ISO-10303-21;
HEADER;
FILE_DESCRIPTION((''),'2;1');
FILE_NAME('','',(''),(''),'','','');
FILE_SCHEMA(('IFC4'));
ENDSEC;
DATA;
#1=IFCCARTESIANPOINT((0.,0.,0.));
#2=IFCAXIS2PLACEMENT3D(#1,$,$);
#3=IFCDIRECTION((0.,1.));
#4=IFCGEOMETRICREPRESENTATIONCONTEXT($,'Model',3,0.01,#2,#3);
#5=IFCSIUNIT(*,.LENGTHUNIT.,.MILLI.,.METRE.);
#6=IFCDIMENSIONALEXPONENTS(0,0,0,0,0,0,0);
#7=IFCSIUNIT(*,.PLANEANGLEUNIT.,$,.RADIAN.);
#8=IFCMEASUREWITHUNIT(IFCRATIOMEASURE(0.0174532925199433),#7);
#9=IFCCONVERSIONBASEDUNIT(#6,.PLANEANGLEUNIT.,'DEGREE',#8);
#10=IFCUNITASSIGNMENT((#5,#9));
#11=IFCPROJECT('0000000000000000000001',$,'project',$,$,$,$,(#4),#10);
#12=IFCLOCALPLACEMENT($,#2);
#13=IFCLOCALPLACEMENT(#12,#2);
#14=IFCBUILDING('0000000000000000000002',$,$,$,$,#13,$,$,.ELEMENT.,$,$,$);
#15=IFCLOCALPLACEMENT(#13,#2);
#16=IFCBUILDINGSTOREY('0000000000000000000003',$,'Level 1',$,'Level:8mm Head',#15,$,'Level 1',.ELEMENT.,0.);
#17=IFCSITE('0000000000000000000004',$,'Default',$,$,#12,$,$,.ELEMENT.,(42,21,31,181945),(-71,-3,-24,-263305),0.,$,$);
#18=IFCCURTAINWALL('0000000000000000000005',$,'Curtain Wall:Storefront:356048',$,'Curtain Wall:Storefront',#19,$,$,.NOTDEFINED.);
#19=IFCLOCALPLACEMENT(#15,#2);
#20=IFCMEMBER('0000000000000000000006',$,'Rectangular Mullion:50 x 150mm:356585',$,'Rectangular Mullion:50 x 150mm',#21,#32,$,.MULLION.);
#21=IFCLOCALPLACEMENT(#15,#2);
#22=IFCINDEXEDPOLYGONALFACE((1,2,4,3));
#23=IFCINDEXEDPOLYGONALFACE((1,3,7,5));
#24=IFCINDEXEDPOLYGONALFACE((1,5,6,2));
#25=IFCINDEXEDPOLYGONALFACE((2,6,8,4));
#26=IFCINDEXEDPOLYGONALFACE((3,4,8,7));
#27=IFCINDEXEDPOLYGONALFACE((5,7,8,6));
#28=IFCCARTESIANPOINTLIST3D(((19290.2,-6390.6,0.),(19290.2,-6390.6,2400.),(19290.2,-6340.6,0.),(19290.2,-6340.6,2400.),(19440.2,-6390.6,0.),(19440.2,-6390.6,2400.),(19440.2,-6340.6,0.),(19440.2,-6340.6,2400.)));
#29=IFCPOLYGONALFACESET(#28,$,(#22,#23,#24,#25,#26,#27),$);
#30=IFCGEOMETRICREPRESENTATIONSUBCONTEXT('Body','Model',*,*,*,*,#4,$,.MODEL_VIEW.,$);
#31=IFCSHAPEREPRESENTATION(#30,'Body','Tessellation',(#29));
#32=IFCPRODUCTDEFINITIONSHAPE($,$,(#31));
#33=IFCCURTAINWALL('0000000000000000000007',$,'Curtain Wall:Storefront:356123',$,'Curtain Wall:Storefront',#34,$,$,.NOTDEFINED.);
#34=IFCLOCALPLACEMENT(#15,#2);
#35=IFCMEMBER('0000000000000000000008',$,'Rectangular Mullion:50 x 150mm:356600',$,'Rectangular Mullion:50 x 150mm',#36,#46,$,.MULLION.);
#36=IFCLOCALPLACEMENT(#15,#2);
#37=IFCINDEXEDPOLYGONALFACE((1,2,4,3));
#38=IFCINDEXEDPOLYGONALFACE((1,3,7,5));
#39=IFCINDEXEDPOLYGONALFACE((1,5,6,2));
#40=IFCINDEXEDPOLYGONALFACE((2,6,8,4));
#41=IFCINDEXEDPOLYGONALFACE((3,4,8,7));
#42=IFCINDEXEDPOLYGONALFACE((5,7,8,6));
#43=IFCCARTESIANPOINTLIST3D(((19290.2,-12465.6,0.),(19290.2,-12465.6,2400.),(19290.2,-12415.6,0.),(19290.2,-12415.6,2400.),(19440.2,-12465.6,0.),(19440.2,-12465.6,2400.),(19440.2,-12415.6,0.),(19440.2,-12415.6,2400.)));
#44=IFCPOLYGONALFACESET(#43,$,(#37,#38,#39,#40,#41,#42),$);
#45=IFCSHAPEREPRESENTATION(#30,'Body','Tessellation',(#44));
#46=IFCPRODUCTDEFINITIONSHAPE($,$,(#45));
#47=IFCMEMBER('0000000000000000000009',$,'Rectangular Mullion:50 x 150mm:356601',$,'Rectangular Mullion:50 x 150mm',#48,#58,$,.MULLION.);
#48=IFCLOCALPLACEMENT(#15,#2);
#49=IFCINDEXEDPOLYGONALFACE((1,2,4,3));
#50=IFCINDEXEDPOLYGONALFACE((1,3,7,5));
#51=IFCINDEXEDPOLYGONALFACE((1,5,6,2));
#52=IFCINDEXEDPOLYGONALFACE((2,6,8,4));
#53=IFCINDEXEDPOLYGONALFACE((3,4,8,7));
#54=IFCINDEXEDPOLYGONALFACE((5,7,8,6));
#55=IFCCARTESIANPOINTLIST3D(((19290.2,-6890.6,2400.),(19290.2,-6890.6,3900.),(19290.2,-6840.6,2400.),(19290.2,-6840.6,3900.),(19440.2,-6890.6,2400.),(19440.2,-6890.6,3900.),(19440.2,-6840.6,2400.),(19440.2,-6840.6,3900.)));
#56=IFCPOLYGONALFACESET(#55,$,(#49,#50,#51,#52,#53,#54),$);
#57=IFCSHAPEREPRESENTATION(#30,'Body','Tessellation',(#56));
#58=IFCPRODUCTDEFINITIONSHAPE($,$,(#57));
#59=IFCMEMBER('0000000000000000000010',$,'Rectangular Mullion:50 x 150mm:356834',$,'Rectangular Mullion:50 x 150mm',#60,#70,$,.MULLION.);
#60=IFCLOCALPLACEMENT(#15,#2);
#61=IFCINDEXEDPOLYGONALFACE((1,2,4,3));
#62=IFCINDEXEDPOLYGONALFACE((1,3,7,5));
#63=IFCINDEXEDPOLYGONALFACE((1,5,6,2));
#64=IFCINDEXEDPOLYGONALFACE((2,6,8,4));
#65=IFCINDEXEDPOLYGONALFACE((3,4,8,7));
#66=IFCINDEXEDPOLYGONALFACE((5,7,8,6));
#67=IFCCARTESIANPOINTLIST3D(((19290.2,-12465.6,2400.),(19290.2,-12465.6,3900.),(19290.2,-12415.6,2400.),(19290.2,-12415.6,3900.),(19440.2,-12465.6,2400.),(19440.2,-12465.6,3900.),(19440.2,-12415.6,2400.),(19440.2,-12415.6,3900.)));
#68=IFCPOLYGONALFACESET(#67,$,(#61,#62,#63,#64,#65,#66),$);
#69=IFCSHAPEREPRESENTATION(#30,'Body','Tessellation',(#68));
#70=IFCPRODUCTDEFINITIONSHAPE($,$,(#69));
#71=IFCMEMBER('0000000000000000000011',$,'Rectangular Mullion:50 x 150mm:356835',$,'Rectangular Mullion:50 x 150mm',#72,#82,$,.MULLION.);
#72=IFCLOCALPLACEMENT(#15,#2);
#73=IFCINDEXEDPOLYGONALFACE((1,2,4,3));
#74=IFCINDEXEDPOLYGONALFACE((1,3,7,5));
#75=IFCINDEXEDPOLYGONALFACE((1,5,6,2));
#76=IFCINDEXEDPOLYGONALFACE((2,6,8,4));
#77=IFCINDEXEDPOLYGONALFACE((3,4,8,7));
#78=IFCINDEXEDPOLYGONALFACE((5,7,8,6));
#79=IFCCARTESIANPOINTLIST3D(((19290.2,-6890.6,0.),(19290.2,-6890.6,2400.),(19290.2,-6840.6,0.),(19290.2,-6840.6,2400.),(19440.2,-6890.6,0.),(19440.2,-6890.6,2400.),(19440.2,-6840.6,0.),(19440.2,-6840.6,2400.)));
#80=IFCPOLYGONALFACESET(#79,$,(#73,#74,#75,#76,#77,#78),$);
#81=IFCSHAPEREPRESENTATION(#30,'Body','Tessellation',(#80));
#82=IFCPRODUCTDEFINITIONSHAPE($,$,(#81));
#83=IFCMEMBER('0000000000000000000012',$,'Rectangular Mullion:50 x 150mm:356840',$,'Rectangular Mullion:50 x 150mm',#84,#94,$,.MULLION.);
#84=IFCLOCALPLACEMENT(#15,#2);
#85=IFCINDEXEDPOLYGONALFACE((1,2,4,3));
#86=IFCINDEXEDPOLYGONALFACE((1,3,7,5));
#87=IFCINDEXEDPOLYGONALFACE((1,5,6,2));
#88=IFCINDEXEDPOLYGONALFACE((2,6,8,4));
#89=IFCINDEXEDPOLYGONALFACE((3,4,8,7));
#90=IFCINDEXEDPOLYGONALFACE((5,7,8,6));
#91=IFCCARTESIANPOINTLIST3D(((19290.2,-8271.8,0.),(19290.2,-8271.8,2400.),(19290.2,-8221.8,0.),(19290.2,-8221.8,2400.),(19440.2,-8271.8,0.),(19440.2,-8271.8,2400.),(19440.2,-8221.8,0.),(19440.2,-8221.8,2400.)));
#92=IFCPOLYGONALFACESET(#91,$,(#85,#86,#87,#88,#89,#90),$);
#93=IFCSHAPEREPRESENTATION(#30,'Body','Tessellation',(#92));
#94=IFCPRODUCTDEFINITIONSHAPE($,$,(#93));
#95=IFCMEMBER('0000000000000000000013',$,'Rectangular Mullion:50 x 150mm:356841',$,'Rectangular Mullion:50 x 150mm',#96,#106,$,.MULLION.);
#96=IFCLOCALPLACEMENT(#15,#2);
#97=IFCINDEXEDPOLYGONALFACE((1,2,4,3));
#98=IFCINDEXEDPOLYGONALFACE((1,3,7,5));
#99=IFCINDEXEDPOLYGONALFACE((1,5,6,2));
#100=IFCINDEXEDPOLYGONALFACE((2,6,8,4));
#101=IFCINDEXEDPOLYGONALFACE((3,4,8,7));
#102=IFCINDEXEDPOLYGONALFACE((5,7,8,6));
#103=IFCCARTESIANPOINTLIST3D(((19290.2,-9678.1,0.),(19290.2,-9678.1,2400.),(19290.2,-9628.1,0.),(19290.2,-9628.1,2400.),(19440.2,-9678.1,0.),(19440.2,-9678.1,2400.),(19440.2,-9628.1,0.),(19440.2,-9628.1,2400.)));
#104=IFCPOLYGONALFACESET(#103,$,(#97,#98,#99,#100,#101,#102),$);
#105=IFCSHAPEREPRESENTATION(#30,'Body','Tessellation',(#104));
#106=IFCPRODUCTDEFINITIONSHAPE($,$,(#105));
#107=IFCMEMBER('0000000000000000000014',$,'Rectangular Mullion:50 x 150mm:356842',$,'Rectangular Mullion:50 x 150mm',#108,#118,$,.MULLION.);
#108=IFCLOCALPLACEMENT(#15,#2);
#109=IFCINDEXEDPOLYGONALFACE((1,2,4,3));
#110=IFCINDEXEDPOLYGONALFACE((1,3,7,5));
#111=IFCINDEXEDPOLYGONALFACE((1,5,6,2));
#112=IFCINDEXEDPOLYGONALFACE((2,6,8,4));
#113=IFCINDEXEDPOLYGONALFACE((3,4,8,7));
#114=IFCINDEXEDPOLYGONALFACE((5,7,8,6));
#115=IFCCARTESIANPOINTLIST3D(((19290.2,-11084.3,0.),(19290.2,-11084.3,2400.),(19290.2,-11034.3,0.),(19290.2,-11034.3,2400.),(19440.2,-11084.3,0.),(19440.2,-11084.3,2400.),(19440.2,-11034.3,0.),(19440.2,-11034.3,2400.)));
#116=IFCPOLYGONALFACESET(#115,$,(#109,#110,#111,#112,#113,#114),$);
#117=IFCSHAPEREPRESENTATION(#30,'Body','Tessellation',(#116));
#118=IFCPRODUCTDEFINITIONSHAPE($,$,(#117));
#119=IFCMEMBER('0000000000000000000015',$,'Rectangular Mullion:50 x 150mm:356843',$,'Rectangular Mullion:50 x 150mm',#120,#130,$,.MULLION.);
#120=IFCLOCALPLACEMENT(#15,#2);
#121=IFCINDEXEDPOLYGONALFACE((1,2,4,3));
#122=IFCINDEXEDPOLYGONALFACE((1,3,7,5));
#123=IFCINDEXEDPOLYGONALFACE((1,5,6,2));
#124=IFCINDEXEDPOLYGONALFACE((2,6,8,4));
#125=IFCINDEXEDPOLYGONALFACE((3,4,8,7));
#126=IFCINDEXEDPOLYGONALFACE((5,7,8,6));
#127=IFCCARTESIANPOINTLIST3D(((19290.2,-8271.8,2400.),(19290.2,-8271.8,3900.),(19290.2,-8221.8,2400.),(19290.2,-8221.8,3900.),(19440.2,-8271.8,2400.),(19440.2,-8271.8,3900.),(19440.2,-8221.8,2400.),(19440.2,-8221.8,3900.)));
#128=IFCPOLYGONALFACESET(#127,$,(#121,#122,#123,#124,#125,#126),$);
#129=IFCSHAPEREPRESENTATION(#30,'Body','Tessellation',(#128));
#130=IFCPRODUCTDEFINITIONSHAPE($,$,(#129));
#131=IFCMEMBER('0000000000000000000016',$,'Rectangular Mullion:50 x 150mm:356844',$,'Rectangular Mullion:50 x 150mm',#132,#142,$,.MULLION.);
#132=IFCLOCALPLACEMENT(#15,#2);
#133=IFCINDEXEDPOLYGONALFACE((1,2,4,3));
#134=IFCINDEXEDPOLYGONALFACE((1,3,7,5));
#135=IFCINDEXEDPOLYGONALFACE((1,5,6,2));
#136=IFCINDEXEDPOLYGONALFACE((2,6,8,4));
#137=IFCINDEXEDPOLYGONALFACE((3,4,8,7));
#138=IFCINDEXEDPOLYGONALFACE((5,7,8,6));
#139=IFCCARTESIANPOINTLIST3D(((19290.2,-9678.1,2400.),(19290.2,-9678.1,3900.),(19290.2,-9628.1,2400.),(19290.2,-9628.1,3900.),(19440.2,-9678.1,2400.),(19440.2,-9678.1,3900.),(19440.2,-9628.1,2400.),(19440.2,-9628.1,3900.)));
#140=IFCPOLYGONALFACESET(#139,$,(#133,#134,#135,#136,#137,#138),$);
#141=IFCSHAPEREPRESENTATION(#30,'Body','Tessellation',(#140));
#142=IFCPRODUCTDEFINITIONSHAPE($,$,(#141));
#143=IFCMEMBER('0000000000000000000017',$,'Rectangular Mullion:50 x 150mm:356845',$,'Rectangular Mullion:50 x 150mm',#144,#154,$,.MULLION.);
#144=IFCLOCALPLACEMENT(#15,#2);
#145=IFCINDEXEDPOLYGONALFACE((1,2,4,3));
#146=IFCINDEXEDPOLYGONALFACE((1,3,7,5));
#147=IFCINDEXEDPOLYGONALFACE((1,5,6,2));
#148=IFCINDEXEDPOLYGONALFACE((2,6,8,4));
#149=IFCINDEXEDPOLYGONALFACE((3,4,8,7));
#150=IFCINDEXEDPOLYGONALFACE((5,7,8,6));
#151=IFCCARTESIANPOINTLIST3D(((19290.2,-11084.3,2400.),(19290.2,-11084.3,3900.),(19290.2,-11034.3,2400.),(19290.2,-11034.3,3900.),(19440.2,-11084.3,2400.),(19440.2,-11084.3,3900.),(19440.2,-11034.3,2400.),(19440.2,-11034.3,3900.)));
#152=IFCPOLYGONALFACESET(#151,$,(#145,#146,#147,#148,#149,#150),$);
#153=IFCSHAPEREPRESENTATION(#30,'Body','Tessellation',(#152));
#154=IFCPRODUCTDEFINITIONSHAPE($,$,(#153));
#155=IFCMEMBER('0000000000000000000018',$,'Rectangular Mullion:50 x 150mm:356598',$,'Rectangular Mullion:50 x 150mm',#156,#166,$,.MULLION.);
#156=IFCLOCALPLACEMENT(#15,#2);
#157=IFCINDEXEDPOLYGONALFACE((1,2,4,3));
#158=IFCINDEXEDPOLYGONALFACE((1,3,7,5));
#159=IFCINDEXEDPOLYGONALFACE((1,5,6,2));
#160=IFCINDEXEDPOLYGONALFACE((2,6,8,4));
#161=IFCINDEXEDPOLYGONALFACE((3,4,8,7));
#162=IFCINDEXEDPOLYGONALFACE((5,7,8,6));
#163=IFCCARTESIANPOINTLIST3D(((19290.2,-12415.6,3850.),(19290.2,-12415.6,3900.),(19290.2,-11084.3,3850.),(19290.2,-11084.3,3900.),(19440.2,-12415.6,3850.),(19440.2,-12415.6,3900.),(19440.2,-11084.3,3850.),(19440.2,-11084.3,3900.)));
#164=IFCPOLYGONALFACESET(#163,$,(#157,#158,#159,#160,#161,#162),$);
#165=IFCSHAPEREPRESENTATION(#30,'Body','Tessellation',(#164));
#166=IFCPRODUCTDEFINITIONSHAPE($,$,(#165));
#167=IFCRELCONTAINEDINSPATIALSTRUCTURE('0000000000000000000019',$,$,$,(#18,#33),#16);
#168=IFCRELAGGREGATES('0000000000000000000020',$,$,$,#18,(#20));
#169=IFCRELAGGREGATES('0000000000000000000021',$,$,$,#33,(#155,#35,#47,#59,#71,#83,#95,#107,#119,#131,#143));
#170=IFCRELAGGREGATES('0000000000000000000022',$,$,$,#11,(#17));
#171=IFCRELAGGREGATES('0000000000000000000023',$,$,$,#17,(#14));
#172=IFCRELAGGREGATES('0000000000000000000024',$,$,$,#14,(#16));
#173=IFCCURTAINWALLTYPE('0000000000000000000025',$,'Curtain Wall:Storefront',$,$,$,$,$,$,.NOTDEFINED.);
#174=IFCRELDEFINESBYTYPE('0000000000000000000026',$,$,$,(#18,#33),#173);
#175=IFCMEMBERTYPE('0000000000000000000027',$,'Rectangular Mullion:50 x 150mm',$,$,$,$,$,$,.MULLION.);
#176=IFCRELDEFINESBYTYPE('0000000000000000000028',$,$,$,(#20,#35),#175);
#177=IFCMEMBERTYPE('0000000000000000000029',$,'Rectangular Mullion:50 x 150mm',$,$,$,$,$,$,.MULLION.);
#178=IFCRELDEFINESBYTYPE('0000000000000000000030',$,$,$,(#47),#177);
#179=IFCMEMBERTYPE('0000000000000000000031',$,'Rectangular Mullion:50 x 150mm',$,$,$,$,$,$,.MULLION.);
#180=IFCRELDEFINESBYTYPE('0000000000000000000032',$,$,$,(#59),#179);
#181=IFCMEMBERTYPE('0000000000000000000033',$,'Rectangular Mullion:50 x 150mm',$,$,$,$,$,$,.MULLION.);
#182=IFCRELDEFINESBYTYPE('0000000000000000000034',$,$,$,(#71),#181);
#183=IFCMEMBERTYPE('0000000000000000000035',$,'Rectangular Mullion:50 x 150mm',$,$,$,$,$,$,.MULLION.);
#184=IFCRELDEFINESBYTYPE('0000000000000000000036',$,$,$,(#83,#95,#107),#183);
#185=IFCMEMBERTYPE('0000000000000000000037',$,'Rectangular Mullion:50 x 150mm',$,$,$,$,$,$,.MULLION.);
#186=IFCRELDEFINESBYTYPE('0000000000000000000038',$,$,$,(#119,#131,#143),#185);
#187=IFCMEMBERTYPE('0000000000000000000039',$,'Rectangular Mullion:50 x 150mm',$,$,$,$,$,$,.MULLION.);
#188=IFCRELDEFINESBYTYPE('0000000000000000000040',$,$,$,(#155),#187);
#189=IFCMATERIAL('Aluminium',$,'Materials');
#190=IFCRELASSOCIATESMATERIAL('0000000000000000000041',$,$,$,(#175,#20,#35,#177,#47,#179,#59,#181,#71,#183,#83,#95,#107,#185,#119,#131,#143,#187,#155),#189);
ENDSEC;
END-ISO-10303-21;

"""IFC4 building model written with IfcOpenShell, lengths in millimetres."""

from ifc_helpers import new_model, entity, si_unit, converted_unit, direction, frame, origin, place, context, subcontext, project, spatial, indexed_curve, outline, extrude, source, transform, mapped, material, type_object, type_shapes, element, aggregate, save


model = new_model("IFC4")

# Units and contexts
model_context = context("Model", 3, precision=0.01, world=origin(), true_north=direction((0.0, 1.0)))
body_context = subcontext(model_context, "Body", "Model", "MODEL_VIEW")
ifc_project = project(units=[si_unit("LENGTHUNIT", "METRE", prefix="MILLI"), converted_unit("PLANEANGLEUNIT", "DEGREE", entity("IfcRatioMeasure", 0.0174532925199433), si_unit("PLANEANGLEUNIT", "RADIAN"), dimensions=[0, 0, 0, 0, 0, 0, 0])], contexts=[model_context])

# Site, building, storey
site_placement = place(None, origin())
site = spatial("IfcSite", under=ifc_project, at=site_placement, Name="Default", CompositionType="ELEMENT", RefLatitude=(42, 21, 31, 181945), RefLongitude=(-71, -3, -24, -263305), RefElevation=0.0)
building_placement = place(site_placement, origin())
building = spatial("IfcBuilding", under=site, at=building_placement, CompositionType="ELEMENT")
storey_placement = place(building_placement, origin())
storey = spatial("IfcBuildingStorey", under=building, at=storey_placement, Name="Level 1", ObjectType="Level:8mm Head", LongName="Level 1", CompositionType="ELEMENT", Elevation=0.0)

# Curtain wall, member
curtain_wall_type_1 = type_object("IfcCurtainWallType", Name="Curtain Wall:Storefront", PredefinedType="NOTDEFINED")
curtain_wall_1_placement = place(storey_placement, origin())
curtain_wall_1 = element("IfcCurtainWall", 1, at=curtain_wall_1_placement, inside=storey, type_object=curtain_wall_type_1, Name="Curtain Wall:Storefront:356048", ObjectType="Curtain Wall:Storefront", PredefinedType="NOTDEFINED")
ifc_material_1 = material(Name="Aluminium", Category="Materials")
member_type_1 = type_object("IfcMemberType", Name="Rectangular Mullion:50 x 150mm", PredefinedType="MULLION", material=ifc_material_1)
shared_shape_1 = source(origin(), body_context, "Body", "SweptSolid", [
    extrude(outline(indexed_curve([(-75.0, -25.0), (75.0, -25.0), (75.0, 25.0), (-75.0, 25.0), (-75.0, -25.0)], self_intersect=False)), frame((-25.0, 0.0, -2400.0), z_axis=(0.0, 0.0, 1.0), x_axis=(0.0, -1.0, 0.0)), (0.0, 0.0, 1.0), 2400.0),
])
type_shapes(member_type_1, [shared_shape_1])
member_1_placement = place(storey_placement, frame((19365.2, -6390.6, 0.0), z_axis=(0.0, 0.0, -1.0), x_axis=(0.0, -1.0, 0.0)))
member_1 = element("IfcMember", 2, at=member_1_placement, type_object=member_type_1, material=ifc_material_1, Name="Rectangular Mullion:50 x 150mm:356585", ObjectType="Rectangular Mullion:50 x 150mm", PredefinedType="MULLION", context=body_context, shape_type="MappedRepresentation", body=[
    mapped(shared_shape_1, transform((0.0, 0.0, 0.0), scale=1.0)),
])
aggregate(curtain_wall_1, [member_1])

# Curtain wall, members
curtain_wall_2_placement = place(storey_placement, origin())
curtain_wall_2 = element("IfcCurtainWall", 3, at=curtain_wall_2_placement, inside=storey, type_object=curtain_wall_type_1, Name="Curtain Wall:Storefront:356123", ObjectType="Curtain Wall:Storefront", PredefinedType="NOTDEFINED")
member_2_placement = place(storey_placement, frame((19365.2, -12465.6, 0.0), z_axis=(0.0, 0.0, -1.0), x_axis=(0.0, -1.0, 0.0)))
member_2 = element("IfcMember", 4, at=member_2_placement, type_object=member_type_1, material=ifc_material_1, Name="Rectangular Mullion:50 x 150mm:356600", ObjectType="Rectangular Mullion:50 x 150mm", PredefinedType="MULLION", context=body_context, shape_type="MappedRepresentation", body=[
    mapped(shared_shape_1, transform((0.0, 0.0, 0.0), scale=1.0)),
])
member_type_2 = type_object("IfcMemberType", Name="Rectangular Mullion:50 x 150mm", PredefinedType="MULLION", material=ifc_material_1)
shared_shape_2 = source(origin(), body_context, "Body", "SweptSolid", [
    extrude(outline(indexed_curve([(-75.0, -25.0), (75.0, -25.0), (75.0, 25.0), (-75.0, 25.0), (-75.0, -25.0)], self_intersect=False)), frame((-25.0, 0.0, -1500.0), z_axis=(0.0, 0.0, 1.0), x_axis=(0.0, -1.0, 0.0)), (0.0, 0.0, 1.0), 1500.0),
])
type_shapes(member_type_2, [shared_shape_2])
member_3_placement = place(storey_placement, frame((19365.2, -6840.6, 3900.0), z_axis=(0.0, 0.0, 1.0), x_axis=(0.0, 1.0, 0.0)))
member_3 = element("IfcMember", 5, at=member_3_placement, type_object=member_type_2, material=ifc_material_1, Name="Rectangular Mullion:50 x 150mm:356601", ObjectType="Rectangular Mullion:50 x 150mm", PredefinedType="MULLION", context=body_context, shape_type="MappedRepresentation", body=[
    mapped(shared_shape_2, transform((0.0, 0.0, 0.0), scale=1.0)),
])
member_type_3 = type_object("IfcMemberType", Name="Rectangular Mullion:50 x 150mm", PredefinedType="MULLION", material=ifc_material_1)
shared_shape_3 = source(origin(), body_context, "Body", "SweptSolid", [
    extrude(outline(indexed_curve([(-75.0, -25.0), (75.0, -25.0), (75.0, 25.0), (-75.0, 25.0), (-75.0, -25.0)], self_intersect=False)), frame((-25.0, 0.0, -1500.0), z_axis=(0.0, 0.0, 1.0), x_axis=(0.0, -1.0, 0.0)), (0.0, 0.0, 1.0), 1500.0),
])
type_shapes(member_type_3, [shared_shape_3])
member_4_placement = place(storey_placement, frame((19365.2, -12465.6, 2400.0), z_axis=(0.0, 0.0, -1.0), x_axis=(0.0, -1.0, 0.0)))
member_4 = element("IfcMember", 6, at=member_4_placement, type_object=member_type_3, material=ifc_material_1, Name="Rectangular Mullion:50 x 150mm:356834", ObjectType="Rectangular Mullion:50 x 150mm", PredefinedType="MULLION", context=body_context, shape_type="MappedRepresentation", body=[
    mapped(shared_shape_3, transform((0.0, 0.0, 0.0), scale=1.0)),
])
member_type_4 = type_object("IfcMemberType", Name="Rectangular Mullion:50 x 150mm", PredefinedType="MULLION", material=ifc_material_1)
shared_shape_4 = source(origin(), body_context, "Body", "SweptSolid", [
    extrude(outline(indexed_curve([(-75.0, -25.0), (75.0, -25.0), (75.0, 25.0), (-75.0, 25.0), (-75.0, -25.0)], self_intersect=False)), frame((-25.0, 0.0, -2400.0), z_axis=(0.0, 0.0, 1.0), x_axis=(0.0, -1.0, 0.0)), (0.0, 0.0, 1.0), 2400.0),
])
type_shapes(member_type_4, [shared_shape_4])
member_5_placement = place(storey_placement, frame((19365.2, -6840.6, 2400.0), z_axis=(0.0, 0.0, 1.0), x_axis=(0.0, 1.0, 0.0)))
member_5 = element("IfcMember", 7, at=member_5_placement, type_object=member_type_4, material=ifc_material_1, Name="Rectangular Mullion:50 x 150mm:356835", ObjectType="Rectangular Mullion:50 x 150mm", PredefinedType="MULLION", context=body_context, shape_type="MappedRepresentation", body=[
    mapped(shared_shape_4, transform((0.0, 0.0, 0.0), scale=1.0)),
])
member_type_5 = type_object("IfcMemberType", Name="Rectangular Mullion:50 x 150mm", PredefinedType="MULLION", material=ifc_material_1)
shared_shape_5 = source(origin(), body_context, "Body", "SweptSolid", [
    extrude(outline(indexed_curve([(-75.0, -25.0), (75.0, -25.0), (75.0, 25.0), (-75.0, 25.0), (-75.0, -25.0)], self_intersect=False)), frame((0.0, 0.0, -2400.0), z_axis=(0.0, 0.0, 1.0), x_axis=(0.0, -1.0, 0.0)), (0.0, 0.0, 1.0), 2400.0),
])
type_shapes(member_type_5, [shared_shape_5])
member_6_placement = place(storey_placement, frame((19365.2, -8246.8, 0.0), z_axis=(0.0, 0.0, -1.0), x_axis=(0.0, -1.0, 0.0)))
member_6 = element("IfcMember", 8, at=member_6_placement, type_object=member_type_5, material=ifc_material_1, Name="Rectangular Mullion:50 x 150mm:356840", ObjectType="Rectangular Mullion:50 x 150mm", PredefinedType="MULLION", context=body_context, shape_type="MappedRepresentation", body=[
    mapped(shared_shape_5, transform((0.0, 0.0, 0.0), scale=1.0)),
])
member_7_placement = place(storey_placement, frame((19365.2, -9653.1, 0.0), z_axis=(0.0, 0.0, -1.0), x_axis=(0.0, -1.0, 0.0)))
member_7 = element("IfcMember", 9, at=member_7_placement, type_object=member_type_5, material=ifc_material_1, Name="Rectangular Mullion:50 x 150mm:356841", ObjectType="Rectangular Mullion:50 x 150mm", PredefinedType="MULLION", context=body_context, shape_type="MappedRepresentation", body=[
    mapped(shared_shape_5, transform((0.0, 0.0, 0.0), scale=1.0)),
])
member_8_placement = place(storey_placement, frame((19365.2, -11059.3, 0.0), z_axis=(0.0, 0.0, -1.0), x_axis=(0.0, -1.0, 0.0)))
member_8 = element("IfcMember", 10, at=member_8_placement, type_object=member_type_5, material=ifc_material_1, Name="Rectangular Mullion:50 x 150mm:356842", ObjectType="Rectangular Mullion:50 x 150mm", PredefinedType="MULLION", context=body_context, shape_type="MappedRepresentation", body=[
    mapped(shared_shape_5, transform((0.0, 0.0, 0.0), scale=1.0)),
])
member_type_6 = type_object("IfcMemberType", Name="Rectangular Mullion:50 x 150mm", PredefinedType="MULLION", material=ifc_material_1)
shared_shape_6 = source(origin(), body_context, "Body", "SweptSolid", [
    extrude(outline(indexed_curve([(-75.0, -25.0), (75.0, -25.0), (75.0, 25.0), (-75.0, 25.0), (-75.0, -25.0)], self_intersect=False)), frame((0.0, 0.0, -1500.0), z_axis=(0.0, 0.0, 1.0), x_axis=(0.0, -1.0, 0.0)), (0.0, 0.0, 1.0), 1500.0),
])
type_shapes(member_type_6, [shared_shape_6])
member_9_placement = place(storey_placement, frame((19365.2, -8246.8, 2400.0), z_axis=(0.0, 0.0, -1.0), x_axis=(0.0, -1.0, 0.0)))
member_9 = element("IfcMember", 11, at=member_9_placement, type_object=member_type_6, material=ifc_material_1, Name="Rectangular Mullion:50 x 150mm:356843", ObjectType="Rectangular Mullion:50 x 150mm", PredefinedType="MULLION", context=body_context, shape_type="MappedRepresentation", body=[
    mapped(shared_shape_6, transform((0.0, 0.0, 0.0), scale=1.0)),
])
member_10_placement = place(storey_placement, frame((19365.2, -9653.1, 2400.0), z_axis=(0.0, 0.0, -1.0), x_axis=(0.0, -1.0, 0.0)))
member_10 = element("IfcMember", 12, at=member_10_placement, type_object=member_type_6, material=ifc_material_1, Name="Rectangular Mullion:50 x 150mm:356844", ObjectType="Rectangular Mullion:50 x 150mm", PredefinedType="MULLION", context=body_context, shape_type="MappedRepresentation", body=[
    mapped(shared_shape_6, transform((0.0, 0.0, 0.0), scale=1.0)),
])
member_11_placement = place(storey_placement, frame((19365.2, -11059.3, 2400.0), z_axis=(0.0, 0.0, -1.0), x_axis=(0.0, -1.0, 0.0)))
member_11 = element("IfcMember", 13, at=member_11_placement, type_object=member_type_6, material=ifc_material_1, Name="Rectangular Mullion:50 x 150mm:356845", ObjectType="Rectangular Mullion:50 x 150mm", PredefinedType="MULLION", context=body_context, shape_type="MappedRepresentation", body=[
    mapped(shared_shape_6, transform((0.0, 0.0, 0.0), scale=1.0)),
])
member_type_7 = type_object("IfcMemberType", Name="Rectangular Mullion:50 x 150mm", PredefinedType="MULLION", material=ifc_material_1)
shared_shape_7 = source(origin(), body_context, "Body", "SweptSolid", [
    extrude(outline(indexed_curve([(-75.0, -25.0), (75.0, -25.0), (75.0, 25.0), (-75.0, 25.0), (-75.0, -25.0)], self_intersect=False)), frame((-25.0, 0.0, -1331.3), z_axis=(0.0, 0.0, 1.0), x_axis=(0.0, -1.0, 0.0)), (0.0, 0.0, 1.0), 1331.3),
])
type_shapes(member_type_7, [shared_shape_7])
member_12_placement = place(storey_placement, frame((19365.2, -12415.6, 3900.0), z_axis=(0.0, -1.0, 0.0), x_axis=(0.0, 0.0, 1.0)))
member_12 = element("IfcMember", 14, at=member_12_placement, type_object=member_type_7, material=ifc_material_1, Name="Rectangular Mullion:50 x 150mm:356598", ObjectType="Rectangular Mullion:50 x 150mm", PredefinedType="MULLION", context=body_context, shape_type="MappedRepresentation", body=[
    mapped(shared_shape_7, transform((0.0, 0.0, 0.0), scale=1.0)),
])

aggregate(curtain_wall_2, [member_12, member_2, member_3, member_4, member_5, member_6, member_7, member_8, member_9, member_10, member_11])

save(model, "model.ifc")
